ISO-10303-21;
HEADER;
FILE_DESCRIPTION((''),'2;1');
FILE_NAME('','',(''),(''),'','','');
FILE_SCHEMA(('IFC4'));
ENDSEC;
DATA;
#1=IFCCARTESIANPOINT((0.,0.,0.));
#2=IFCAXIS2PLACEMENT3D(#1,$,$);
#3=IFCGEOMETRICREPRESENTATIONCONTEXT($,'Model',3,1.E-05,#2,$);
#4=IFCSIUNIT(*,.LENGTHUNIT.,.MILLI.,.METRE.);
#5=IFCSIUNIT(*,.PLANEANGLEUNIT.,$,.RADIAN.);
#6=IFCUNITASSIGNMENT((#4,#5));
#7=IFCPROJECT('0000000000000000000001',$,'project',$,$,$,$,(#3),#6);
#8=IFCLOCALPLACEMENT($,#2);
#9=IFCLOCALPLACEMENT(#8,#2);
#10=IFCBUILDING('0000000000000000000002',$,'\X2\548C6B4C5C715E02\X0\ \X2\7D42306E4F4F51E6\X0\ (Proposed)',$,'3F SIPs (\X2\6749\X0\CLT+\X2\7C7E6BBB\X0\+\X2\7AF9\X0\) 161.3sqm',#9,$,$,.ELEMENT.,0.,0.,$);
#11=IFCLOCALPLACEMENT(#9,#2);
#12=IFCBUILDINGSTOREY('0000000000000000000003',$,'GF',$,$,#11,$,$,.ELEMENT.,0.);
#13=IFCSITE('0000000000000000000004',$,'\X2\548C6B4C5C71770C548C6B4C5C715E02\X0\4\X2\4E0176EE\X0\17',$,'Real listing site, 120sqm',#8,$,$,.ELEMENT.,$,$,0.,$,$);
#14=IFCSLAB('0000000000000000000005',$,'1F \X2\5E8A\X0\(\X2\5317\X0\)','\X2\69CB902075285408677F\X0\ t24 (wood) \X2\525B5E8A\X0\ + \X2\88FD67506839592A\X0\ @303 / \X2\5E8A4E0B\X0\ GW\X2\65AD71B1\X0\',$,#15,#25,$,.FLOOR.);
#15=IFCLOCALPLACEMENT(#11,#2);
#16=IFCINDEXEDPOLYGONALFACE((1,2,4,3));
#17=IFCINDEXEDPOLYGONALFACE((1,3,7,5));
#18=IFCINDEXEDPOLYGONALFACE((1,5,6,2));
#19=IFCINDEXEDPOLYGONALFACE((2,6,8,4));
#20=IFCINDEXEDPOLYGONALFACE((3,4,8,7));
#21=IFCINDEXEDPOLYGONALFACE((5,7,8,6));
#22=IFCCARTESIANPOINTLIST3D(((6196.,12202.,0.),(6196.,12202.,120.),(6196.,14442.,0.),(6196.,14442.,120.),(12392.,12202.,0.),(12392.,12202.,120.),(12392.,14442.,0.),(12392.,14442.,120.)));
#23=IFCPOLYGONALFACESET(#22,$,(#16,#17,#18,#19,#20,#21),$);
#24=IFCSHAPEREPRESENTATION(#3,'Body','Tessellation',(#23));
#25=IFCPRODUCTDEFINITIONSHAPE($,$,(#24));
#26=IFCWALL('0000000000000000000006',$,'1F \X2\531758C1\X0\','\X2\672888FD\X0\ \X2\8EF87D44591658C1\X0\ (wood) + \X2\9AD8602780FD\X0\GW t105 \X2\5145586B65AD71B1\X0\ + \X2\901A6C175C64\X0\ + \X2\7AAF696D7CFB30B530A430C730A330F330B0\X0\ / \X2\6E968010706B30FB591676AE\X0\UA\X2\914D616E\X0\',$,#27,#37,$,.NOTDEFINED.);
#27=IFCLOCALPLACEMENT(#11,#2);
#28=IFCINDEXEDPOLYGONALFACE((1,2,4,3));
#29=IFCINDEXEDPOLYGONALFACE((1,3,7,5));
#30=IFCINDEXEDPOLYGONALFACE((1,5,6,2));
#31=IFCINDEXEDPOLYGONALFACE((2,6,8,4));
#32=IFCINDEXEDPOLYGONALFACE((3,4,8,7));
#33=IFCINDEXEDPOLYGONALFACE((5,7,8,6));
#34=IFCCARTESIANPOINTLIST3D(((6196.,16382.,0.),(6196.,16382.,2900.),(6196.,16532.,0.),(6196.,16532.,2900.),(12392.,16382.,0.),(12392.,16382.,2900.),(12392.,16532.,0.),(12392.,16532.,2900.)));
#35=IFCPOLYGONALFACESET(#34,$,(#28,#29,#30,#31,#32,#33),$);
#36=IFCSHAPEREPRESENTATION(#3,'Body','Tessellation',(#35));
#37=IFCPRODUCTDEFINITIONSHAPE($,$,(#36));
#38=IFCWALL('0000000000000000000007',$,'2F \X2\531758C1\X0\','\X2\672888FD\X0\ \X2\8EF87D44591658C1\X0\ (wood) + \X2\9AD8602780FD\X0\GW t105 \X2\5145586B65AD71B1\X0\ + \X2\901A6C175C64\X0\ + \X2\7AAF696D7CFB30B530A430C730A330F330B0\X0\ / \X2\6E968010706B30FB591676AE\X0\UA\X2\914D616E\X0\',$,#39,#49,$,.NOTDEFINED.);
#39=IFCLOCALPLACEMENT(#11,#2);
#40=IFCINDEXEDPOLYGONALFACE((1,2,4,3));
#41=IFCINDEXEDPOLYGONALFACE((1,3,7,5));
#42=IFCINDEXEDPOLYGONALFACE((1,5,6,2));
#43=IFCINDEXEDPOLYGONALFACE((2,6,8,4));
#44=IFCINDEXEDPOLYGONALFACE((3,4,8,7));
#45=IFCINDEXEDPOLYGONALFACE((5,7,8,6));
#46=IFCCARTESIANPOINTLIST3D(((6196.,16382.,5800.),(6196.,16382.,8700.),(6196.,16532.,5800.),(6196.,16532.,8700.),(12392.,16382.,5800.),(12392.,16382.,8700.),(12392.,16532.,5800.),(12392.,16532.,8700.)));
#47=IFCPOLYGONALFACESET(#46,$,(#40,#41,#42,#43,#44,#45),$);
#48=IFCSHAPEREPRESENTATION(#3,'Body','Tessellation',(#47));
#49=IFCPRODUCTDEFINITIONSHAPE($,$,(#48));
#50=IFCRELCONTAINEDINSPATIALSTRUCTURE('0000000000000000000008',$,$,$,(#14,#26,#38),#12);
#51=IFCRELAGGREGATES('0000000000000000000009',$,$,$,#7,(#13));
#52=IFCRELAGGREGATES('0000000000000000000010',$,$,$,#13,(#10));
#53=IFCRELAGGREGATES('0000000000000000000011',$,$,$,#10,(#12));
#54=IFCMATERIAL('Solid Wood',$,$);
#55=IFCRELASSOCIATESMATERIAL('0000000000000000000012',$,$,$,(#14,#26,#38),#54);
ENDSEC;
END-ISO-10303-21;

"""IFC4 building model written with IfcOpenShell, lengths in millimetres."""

from ifc_helpers import new_model, si_unit, frame, frame_2d, origin, place, context, project, spatial, rectangle, extrude, material, element, save


model = new_model("IFC4")

# Units and contexts
model_context = context("Model", 3, precision=1e-05, world=origin())
ifc_project = project(units=[si_unit("LENGTHUNIT", "METRE", prefix="MILLI"), si_unit("PLANEANGLEUNIT", "RADIAN")], contexts=[model_context])

# Site, building, storey
site_placement = place(None, origin())
site = spatial("IfcSite", under=ifc_project, at=site_placement, Name="和歌山県和歌山市4丁目17", ObjectType="Real listing site, 120sqm", CompositionType="ELEMENT", RefElevation=0.0)
building_placement = place(site_placement, origin())
building = spatial("IfcBuilding", under=site, at=building_placement, Name="和歌山市 終の住処 (Proposed)", ObjectType="3F SIPs (杉CLT+籾殻+竹) 161.3sqm", CompositionType="ELEMENT", ElevationOfRefHeight=0.0, ElevationOfTerrain=0.0)
storey_placement = place(building_placement, origin())
storey = spatial("IfcBuildingStorey", under=building, at=storey_placement, Name="GF", CompositionType="ELEMENT", Elevation=0.0)

# Slab
ifc_material_1 = material(Name="Solid Wood")
slab_1_placement = place(storey_placement, frame((3098.0, 6101.0, 0.0)))
element("IfcSlab", 1, at=slab_1_placement, inside=storey, material=ifc_material_1, Name="1F 床(北)", Description="構造用合板 t24 (wood) 剛床 + 製材根太 @303 / 床下 GW断熱", PredefinedType="FLOOR", context=model_context, shape_type="SweptSolid", body=[
    extrude(rectangle(XDim=6196.0, YDim=2240.0, at=frame_2d((3098.0, 1120.0))), frame((3098.0, 6101.0, 0.0)), (0.0, 0.0, 1.0), 120.0),
])

# Wall
wall_1_placement = place(storey_placement, frame((3098.0, 8191.0, 0.0)))
element("IfcWall", 2, at=wall_1_placement, inside=storey, material=ifc_material_1, Name="1F 北壁", Description="木製 軸組外壁 (wood) + 高性能GW t105 充填断熱 + 通気層 + 窯業系サイディング / 準耐火・外皮UA配慮", PredefinedType="NOTDEFINED", context=model_context, shape_type="SweptSolid", body=[
    extrude(rectangle(XDim=6196.0, YDim=150.0, at=frame_2d((3098.0, 75.0))), frame((3098.0, 8191.0, 0.0)), (0.0, 0.0, 1.0), 2900.0),
])

# Wall
wall_2_placement = place(storey_placement, frame((3098.0, 8191.0, 2900.0)))
element("IfcWall", 3, at=wall_2_placement, inside=storey, material=ifc_material_1, Name="2F 北壁", Description="木製 軸組外壁 (wood) + 高性能GW t105 充填断熱 + 通気層 + 窯業系サイディング / 準耐火・外皮UA配慮", PredefinedType="NOTDEFINED", context=model_context, shape_type="SweptSolid", body=[
    extrude(rectangle(XDim=6196.0, YDim=150.0, at=frame_2d((3098.0, 75.0))), frame((3098.0, 8191.0, 2900.0)), (0.0, 0.0, 1.0), 2900.0),
])

save(model, "model.ifc")
